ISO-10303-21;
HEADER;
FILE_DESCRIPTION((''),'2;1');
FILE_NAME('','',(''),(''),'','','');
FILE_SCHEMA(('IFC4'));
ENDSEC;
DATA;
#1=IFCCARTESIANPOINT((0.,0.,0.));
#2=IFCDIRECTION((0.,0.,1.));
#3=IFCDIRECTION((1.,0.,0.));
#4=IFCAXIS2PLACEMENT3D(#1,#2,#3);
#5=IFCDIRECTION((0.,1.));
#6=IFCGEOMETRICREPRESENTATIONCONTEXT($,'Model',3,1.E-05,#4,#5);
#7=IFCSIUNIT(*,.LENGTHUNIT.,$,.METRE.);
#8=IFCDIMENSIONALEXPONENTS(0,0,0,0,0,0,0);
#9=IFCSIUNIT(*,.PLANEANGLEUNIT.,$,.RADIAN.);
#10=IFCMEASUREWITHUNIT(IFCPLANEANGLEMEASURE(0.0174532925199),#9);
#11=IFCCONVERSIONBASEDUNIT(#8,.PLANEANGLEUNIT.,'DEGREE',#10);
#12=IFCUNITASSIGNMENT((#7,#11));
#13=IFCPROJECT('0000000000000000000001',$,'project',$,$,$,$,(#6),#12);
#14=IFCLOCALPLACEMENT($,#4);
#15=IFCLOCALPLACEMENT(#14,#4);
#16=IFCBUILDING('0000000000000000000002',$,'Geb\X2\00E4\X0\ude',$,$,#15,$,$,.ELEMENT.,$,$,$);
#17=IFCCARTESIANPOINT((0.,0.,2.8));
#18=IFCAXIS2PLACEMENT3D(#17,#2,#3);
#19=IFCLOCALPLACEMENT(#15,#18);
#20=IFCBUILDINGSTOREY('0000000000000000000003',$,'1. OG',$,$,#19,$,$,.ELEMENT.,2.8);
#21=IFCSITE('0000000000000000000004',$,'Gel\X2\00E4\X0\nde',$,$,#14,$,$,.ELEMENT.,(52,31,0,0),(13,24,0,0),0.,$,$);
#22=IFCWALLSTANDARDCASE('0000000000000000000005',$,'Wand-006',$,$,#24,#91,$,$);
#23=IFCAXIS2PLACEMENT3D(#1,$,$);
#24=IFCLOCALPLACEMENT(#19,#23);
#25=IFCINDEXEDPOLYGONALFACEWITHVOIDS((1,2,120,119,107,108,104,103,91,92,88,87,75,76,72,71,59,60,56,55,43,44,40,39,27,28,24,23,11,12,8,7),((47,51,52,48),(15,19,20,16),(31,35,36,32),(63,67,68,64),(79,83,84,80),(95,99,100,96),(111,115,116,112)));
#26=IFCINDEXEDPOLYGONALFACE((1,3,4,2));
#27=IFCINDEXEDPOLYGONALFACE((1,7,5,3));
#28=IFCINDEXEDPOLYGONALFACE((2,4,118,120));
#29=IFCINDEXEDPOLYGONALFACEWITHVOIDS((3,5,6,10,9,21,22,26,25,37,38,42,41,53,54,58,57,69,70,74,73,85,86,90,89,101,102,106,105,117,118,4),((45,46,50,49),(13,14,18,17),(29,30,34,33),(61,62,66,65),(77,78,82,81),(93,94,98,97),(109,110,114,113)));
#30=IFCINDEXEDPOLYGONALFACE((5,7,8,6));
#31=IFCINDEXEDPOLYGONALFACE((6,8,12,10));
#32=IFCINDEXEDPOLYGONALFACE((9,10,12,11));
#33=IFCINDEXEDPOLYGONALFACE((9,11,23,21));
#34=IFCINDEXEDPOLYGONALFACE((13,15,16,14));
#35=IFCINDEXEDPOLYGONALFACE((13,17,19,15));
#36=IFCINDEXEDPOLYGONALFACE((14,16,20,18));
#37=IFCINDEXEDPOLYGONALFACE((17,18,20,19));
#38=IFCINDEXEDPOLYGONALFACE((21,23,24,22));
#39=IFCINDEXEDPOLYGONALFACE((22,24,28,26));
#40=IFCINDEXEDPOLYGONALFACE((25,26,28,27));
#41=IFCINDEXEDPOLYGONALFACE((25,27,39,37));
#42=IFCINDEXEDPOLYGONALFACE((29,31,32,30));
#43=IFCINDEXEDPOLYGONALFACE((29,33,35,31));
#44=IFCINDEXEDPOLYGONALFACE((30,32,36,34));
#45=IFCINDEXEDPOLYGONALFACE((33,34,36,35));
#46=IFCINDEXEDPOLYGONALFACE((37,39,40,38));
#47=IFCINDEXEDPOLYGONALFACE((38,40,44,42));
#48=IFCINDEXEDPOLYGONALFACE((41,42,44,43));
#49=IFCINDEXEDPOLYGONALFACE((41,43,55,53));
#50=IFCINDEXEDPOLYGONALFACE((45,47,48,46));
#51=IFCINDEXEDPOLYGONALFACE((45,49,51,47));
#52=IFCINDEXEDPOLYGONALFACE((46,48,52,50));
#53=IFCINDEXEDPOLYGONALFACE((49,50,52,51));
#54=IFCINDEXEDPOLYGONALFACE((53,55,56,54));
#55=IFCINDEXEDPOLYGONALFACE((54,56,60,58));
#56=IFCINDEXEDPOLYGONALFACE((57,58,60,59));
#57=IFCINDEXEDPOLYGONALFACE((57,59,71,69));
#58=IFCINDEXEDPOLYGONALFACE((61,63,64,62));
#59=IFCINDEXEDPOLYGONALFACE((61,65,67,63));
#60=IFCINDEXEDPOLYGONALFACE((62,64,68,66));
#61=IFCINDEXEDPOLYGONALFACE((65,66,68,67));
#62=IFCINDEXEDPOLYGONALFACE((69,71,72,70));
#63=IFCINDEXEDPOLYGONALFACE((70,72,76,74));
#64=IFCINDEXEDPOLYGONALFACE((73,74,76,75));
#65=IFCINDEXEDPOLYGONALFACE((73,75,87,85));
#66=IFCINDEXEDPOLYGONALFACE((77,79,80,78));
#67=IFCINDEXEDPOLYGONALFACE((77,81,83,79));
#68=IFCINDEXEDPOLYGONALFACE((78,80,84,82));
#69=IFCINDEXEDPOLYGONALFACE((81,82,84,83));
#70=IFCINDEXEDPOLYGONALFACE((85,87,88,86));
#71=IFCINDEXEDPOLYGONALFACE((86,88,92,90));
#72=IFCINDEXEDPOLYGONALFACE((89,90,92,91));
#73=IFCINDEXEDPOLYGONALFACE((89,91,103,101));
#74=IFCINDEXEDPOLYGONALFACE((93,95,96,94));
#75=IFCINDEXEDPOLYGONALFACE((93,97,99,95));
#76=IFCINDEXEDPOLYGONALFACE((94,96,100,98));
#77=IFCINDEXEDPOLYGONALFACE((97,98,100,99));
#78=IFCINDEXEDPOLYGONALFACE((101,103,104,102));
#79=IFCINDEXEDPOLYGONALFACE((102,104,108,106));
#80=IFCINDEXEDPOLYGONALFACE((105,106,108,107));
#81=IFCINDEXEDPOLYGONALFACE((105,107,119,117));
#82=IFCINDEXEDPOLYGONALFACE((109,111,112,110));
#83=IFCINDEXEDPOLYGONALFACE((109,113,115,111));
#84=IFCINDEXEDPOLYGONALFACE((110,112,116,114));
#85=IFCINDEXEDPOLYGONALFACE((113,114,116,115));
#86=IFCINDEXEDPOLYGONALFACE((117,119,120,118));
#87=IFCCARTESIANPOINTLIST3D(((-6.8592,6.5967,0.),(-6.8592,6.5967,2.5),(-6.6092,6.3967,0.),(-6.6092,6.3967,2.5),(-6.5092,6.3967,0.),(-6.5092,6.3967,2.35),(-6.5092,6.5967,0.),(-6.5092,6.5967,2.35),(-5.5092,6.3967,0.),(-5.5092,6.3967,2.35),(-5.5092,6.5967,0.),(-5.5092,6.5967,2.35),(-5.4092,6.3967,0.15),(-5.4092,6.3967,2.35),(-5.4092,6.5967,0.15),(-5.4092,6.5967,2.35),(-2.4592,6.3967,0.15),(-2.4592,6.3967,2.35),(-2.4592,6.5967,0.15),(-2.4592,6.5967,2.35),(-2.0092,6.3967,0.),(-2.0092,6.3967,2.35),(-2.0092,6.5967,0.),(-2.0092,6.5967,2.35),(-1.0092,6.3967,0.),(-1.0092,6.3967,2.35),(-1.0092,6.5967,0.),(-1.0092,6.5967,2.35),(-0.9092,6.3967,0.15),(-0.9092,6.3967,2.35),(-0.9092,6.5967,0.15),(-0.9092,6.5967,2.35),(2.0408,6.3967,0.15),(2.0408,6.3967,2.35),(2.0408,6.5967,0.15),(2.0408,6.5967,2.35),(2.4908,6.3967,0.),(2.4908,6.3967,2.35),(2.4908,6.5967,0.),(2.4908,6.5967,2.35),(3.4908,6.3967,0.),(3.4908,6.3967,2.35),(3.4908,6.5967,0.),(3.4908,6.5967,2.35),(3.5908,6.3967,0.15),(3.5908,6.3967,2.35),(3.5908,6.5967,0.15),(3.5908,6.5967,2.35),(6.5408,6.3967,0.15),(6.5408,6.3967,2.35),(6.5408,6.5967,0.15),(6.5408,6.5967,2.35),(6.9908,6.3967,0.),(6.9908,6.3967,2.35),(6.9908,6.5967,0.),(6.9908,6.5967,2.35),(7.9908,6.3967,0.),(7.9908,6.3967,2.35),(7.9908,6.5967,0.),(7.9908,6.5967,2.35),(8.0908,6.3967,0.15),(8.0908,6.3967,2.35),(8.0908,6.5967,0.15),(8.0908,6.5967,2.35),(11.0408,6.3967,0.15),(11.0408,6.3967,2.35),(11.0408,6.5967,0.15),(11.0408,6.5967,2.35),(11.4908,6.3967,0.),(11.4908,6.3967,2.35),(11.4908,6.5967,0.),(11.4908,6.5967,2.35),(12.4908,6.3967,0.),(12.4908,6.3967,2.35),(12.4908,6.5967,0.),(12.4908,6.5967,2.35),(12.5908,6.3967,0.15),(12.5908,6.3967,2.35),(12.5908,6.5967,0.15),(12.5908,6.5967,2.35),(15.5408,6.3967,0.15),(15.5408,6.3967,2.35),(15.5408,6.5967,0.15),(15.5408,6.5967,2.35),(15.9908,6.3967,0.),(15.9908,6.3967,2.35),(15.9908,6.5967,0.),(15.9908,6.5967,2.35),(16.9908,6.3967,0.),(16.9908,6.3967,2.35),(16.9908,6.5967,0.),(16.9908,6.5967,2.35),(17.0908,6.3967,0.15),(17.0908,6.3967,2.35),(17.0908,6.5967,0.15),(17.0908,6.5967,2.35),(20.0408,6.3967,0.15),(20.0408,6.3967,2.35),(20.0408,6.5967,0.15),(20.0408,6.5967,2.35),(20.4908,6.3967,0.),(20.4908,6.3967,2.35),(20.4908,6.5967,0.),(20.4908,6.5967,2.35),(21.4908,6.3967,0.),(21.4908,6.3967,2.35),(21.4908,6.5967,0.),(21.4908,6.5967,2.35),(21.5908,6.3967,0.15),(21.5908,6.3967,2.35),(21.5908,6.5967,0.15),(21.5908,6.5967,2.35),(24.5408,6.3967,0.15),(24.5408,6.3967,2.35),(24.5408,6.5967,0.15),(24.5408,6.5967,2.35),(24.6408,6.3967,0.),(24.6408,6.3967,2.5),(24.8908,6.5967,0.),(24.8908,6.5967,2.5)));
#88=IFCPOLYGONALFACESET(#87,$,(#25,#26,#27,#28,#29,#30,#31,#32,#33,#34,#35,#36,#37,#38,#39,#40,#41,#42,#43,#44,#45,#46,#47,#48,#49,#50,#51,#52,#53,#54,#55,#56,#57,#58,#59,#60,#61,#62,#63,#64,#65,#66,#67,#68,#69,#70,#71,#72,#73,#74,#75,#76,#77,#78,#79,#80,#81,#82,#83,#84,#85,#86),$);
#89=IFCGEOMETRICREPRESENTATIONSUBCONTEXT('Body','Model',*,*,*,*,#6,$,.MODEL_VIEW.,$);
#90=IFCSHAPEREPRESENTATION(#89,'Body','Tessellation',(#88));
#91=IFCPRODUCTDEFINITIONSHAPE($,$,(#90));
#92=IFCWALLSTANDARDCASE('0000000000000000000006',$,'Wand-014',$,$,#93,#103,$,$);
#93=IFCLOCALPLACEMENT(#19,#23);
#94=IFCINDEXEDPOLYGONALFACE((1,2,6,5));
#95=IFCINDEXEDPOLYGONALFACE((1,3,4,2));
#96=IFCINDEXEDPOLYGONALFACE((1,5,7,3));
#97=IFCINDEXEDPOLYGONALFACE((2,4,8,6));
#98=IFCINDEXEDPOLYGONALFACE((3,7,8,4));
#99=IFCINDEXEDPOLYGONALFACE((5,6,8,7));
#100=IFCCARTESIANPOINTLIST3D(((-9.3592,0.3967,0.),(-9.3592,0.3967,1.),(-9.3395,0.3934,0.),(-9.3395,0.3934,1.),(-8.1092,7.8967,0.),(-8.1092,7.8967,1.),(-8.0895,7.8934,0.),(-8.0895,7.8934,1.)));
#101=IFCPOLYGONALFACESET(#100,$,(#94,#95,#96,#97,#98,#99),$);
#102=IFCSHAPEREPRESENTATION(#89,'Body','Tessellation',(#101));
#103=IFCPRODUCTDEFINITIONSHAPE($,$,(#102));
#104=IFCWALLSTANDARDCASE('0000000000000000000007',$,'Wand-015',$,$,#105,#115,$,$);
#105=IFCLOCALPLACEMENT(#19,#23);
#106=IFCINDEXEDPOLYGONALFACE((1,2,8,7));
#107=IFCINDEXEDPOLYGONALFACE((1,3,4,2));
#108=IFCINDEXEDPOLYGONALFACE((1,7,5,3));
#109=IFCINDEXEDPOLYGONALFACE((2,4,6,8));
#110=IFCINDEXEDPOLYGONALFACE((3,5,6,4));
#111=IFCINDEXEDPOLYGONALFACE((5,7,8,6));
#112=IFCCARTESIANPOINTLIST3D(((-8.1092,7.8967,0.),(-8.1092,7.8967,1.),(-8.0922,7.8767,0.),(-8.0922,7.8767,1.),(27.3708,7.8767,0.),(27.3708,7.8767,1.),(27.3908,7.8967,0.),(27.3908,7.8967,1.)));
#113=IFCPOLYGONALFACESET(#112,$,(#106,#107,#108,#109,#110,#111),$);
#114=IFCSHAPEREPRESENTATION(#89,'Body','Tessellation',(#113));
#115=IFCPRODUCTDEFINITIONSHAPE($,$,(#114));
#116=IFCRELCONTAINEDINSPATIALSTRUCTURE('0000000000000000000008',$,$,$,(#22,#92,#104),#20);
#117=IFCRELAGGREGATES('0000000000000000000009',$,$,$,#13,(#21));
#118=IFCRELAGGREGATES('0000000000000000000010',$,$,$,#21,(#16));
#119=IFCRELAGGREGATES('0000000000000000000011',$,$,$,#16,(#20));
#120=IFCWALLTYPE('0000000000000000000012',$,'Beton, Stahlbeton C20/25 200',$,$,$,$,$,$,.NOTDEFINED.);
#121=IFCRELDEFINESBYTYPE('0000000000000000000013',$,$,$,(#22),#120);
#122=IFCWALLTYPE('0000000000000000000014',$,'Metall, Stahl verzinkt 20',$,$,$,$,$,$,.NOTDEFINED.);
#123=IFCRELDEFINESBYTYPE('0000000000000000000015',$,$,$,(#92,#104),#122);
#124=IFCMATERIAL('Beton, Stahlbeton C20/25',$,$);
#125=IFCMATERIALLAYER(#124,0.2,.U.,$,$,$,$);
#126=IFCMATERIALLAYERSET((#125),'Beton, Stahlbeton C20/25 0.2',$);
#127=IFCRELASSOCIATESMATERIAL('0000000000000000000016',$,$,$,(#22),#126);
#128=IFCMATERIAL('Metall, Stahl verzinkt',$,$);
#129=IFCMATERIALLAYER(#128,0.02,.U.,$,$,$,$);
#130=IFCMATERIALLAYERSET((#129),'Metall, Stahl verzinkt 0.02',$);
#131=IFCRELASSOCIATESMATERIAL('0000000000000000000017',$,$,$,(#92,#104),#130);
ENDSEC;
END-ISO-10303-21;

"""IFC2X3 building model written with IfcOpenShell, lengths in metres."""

from ifc_helpers import new_model, entity, si_unit, converted_unit, direction, frame, origin_with_axes, origin_2d_with_axis, place, context, subcontext, project, spatial, polyline, rectangle, outline, extrude, material, layer, layer_set, layer_usage, type_object, element, save


model = new_model("IFC2X3")

# Units and contexts
model_context = context("Model", 3, precision=1e-05, world=origin_with_axes(), true_north=direction((0.0, 1.0)))
body_context = subcontext(model_context, "Body", "Model", "MODEL_VIEW")
ifc_project = project(units=[si_unit("LENGTHUNIT", "METRE"), converted_unit("PLANEANGLEUNIT", "DEGREE", entity("IfcPlaneAngleMeasure", 0.0174532925199), si_unit("PLANEANGLEUNIT", "RADIAN"), dimensions=[0, 0, 0, 0, 0, 0, 0])], contexts=[model_context])

# Site, building, storey
site_placement = place(None, origin_with_axes())
site = spatial("IfcSite", under=ifc_project, at=site_placement, Name="Gelände", CompositionType="ELEMENT", RefLatitude=(52, 31, 0, 0), RefLongitude=(13, 24, 0, 0), RefElevation=0.0)
building_placement = place(site_placement, origin_with_axes())
building = spatial("IfcBuilding", under=site, at=building_placement, Name="Gebäude", CompositionType="ELEMENT")
storey_placement = place(building_placement, frame((0.0, 0.0, 2.8), z_axis=(0.0, 0.0, 1.0), x_axis=(1.0, 0.0, 0.0)))
storey = spatial("IfcBuildingStorey", under=building, at=storey_placement, Name="1. OG", CompositionType="ELEMENT", Elevation=2.8)

# Shared definitions
ifc_material_1 = material(Name="Beton, Stahlbeton C20/25")

# Wall, openings
ifc_layer_1 = layer(ifc_material_1, 0.2, ventilated="UNKNOWN")
ifc_layer_set_1 = layer_set([ifc_layer_1], Name="Beton, Stahlbeton C20/25 0.2")
ifc_layer_usage_1 = layer_usage(ifc_layer_set_1, "AXIS2", "POSITIVE", 0.0)
wall_type_1 = type_object("IfcWallType", Name="Beton, Stahlbeton C20/25 200", PredefinedType="NOTDEFINED")
wall_1_placement = place(storey_placement, frame((-6.6092, 6.3967, 0.0), z_axis=(0.0, 0.0, 1.0), x_axis=(1.0, 0.0, 0.0)))
wall_1 = element("IfcWallStandardCase", 1, at=wall_1_placement, inside=storey, type_object=wall_type_1, material=ifc_layer_usage_1, Name="Wand-006", context=body_context, shape_type="SweptSolid", body=[
    extrude(outline(polyline([(0.0, 0.0), (31.25, 0.0), (31.5, 0.2), (-0.25, 0.2), (0.0, 0.0)])), origin_with_axes(), (0.0, 0.0, 1.0), 2.5),
])
opening_1_placement = place(wall_1_placement, frame((7.175, 0.0, 0.15), z_axis=(0.0, 0.0, 1.0), x_axis=(1.0, 0.0, 0.0)))
element("IfcOpeningElement", 2, at=opening_1_placement, cuts=wall_1, context=body_context, shape_type="SweptSolid", body=[
    extrude(rectangle(XDim=2.95, YDim=2.2, at=origin_2d_with_axis()), frame((0.0, -0.2, 1.1), z_axis=(0.0, -1.0, 0.0), x_axis=(1.0, 0.0, 0.0)), (0.0, 0.0, -1.0), 0.6),
])
opening_2_placement = place(wall_1_placement, frame((11.675, 0.0, 0.15), z_axis=(0.0, 0.0, 1.0), x_axis=(1.0, 0.0, 0.0)))
element("IfcOpeningElement", 3, at=opening_2_placement, cuts=wall_1, context=body_context, shape_type="SweptSolid", body=[
    extrude(rectangle(XDim=2.95, YDim=2.2, at=origin_2d_with_axis()), frame((0.0, -0.2, 1.1), z_axis=(0.0, -1.0, 0.0), x_axis=(1.0, 0.0, 0.0)), (0.0, 0.0, -1.0), 0.6),
])
opening_3_placement = place(wall_1_placement, frame((23.1, 0.0, 0.0), z_axis=(0.0, 0.0, 1.0), x_axis=(1.0, 0.0, 0.0)))
element("IfcOpeningElement", 4, at=opening_3_placement, cuts=wall_1, context=body_context, shape_type="SweptSolid", body=[
    extrude(rectangle(XDim=1.0, YDim=2.35, at=origin_2d_with_axis()), frame((0.0, 0.4, 1.175), z_axis=(0.0, 1.0, 0.0), x_axis=(-1.0, 0.0, 0.0)), (0.0, 0.0, -1.0), 0.6),
])
opening_4_placement = place(wall_1_placement, frame((18.6, 0.0, 0.0), z_axis=(0.0, 0.0, 1.0), x_axis=(1.0, 0.0, 0.0)))
element("IfcOpeningElement", 5, at=opening_4_placement, cuts=wall_1, context=body_context, shape_type="SweptSolid", body=[
    extrude(rectangle(XDim=1.0, YDim=2.35, at=origin_2d_with_axis()), frame((0.0, 0.4, 1.175), z_axis=(0.0, 1.0, 0.0), x_axis=(-1.0, 0.0, 0.0)), (0.0, 0.0, -1.0), 0.6),
])
opening_5_placement = place(wall_1_placement, frame((0.6, 0.0, 0.0), z_axis=(0.0, 0.0, 1.0), x_axis=(1.0, 0.0, 0.0)))
element("IfcOpeningElement", 6, at=opening_5_placement, cuts=wall_1, context=body_context, shape_type="SweptSolid", body=[
    extrude(rectangle(XDim=1.0, YDim=2.35, at=origin_2d_with_axis()), frame((0.0, 0.4, 1.175), z_axis=(0.0, 1.0, 0.0), x_axis=(-1.0, 0.0, 0.0)), (0.0, 0.0, -1.0), 0.6),
])
opening_6_placement = place(wall_1_placement, frame((25.175, 0.0, 0.15), z_axis=(0.0, 0.0, 1.0), x_axis=(1.0, 0.0, 0.0)))
element("IfcOpeningElement", 7, at=opening_6_placement, cuts=wall_1, context=body_context, shape_type="SweptSolid", body=[
    extrude(rectangle(XDim=2.95, YDim=2.2, at=origin_2d_with_axis()), frame((0.0, -0.2, 1.1), z_axis=(0.0, -1.0, 0.0), x_axis=(1.0, 0.0, 0.0)), (0.0, 0.0, -1.0), 0.6),
])
opening_7_placement = place(wall_1_placement, frame((9.6, 0.0, 0.0), z_axis=(0.0, 0.0, 1.0), x_axis=(1.0, 0.0, 0.0)))
element("IfcOpeningElement", 8, at=opening_7_placement, cuts=wall_1, context=body_context, shape_type="SweptSolid", body=[
    extrude(rectangle(XDim=1.0, YDim=2.35, at=origin_2d_with_axis()), frame((0.0, 0.4, 1.175), z_axis=(0.0, 1.0, 0.0), x_axis=(-1.0, 0.0, 0.0)), (0.0, 0.0, -1.0), 0.6),
])
opening_8_placement = place(wall_1_placement, frame((2.675, 0.0, 0.15), z_axis=(0.0, 0.0, 1.0), x_axis=(1.0, 0.0, 0.0)))
element("IfcOpeningElement", 9, at=opening_8_placement, cuts=wall_1, context=body_context, shape_type="SweptSolid", body=[
    extrude(rectangle(XDim=2.95, YDim=2.2, at=origin_2d_with_axis()), frame((0.0, -0.2, 1.1), z_axis=(0.0, -1.0, 0.0), x_axis=(1.0, 0.0, 0.0)), (0.0, 0.0, -1.0), 0.6),
])
opening_9_placement = place(wall_1_placement, frame((16.175, 0.0, 0.15), z_axis=(0.0, 0.0, 1.0), x_axis=(1.0, 0.0, 0.0)))
element("IfcOpeningElement", 10, at=opening_9_placement, cuts=wall_1, context=body_context, shape_type="SweptSolid", body=[
    extrude(rectangle(XDim=2.95, YDim=2.2, at=origin_2d_with_axis()), frame((0.0, -0.2, 1.1), z_axis=(0.0, -1.0, 0.0), x_axis=(1.0, 0.0, 0.0)), (0.0, 0.0, -1.0), 0.6),
])
opening_10_placement = place(wall_1_placement, frame((29.675, 0.0, 0.15), z_axis=(0.0, 0.0, 1.0), x_axis=(1.0, 0.0, 0.0)))
element("IfcOpeningElement", 11, at=opening_10_placement, cuts=wall_1, context=body_context, shape_type="SweptSolid", body=[
    extrude(rectangle(XDim=2.95, YDim=2.2, at=origin_2d_with_axis()), frame((0.0, -0.2, 1.1), z_axis=(0.0, -1.0, 0.0), x_axis=(1.0, 0.0, 0.0)), (0.0, 0.0, -1.0), 0.6),
])
opening_11_placement = place(wall_1_placement, frame((14.1, 0.0, 0.0), z_axis=(0.0, 0.0, 1.0), x_axis=(1.0, 0.0, 0.0)))
element("IfcOpeningElement", 12, at=opening_11_placement, cuts=wall_1, context=body_context, shape_type="SweptSolid", body=[
    extrude(rectangle(XDim=1.0, YDim=2.35, at=origin_2d_with_axis()), frame((0.0, 0.4, 1.175), z_axis=(0.0, 1.0, 0.0), x_axis=(-1.0, 0.0, 0.0)), (0.0, 0.0, -1.0), 0.6),
])
opening_12_placement = place(wall_1_placement, frame((20.675, 0.0, 0.15), z_axis=(0.0, 0.0, 1.0), x_axis=(1.0, 0.0, 0.0)))
element("IfcOpeningElement", 13, at=opening_12_placement, cuts=wall_1, context=body_context, shape_type="SweptSolid", body=[
    extrude(rectangle(XDim=2.95, YDim=2.2, at=origin_2d_with_axis()), frame((0.0, -0.2, 1.1), z_axis=(0.0, -1.0, 0.0), x_axis=(1.0, 0.0, 0.0)), (0.0, 0.0, -1.0), 0.6),
])
opening_13_placement = place(wall_1_placement, frame((27.6, 0.0, 0.0), z_axis=(0.0, 0.0, 1.0), x_axis=(1.0, 0.0, 0.0)))
element("IfcOpeningElement", 14, at=opening_13_placement, cuts=wall_1, context=body_context, shape_type="SweptSolid", body=[
    extrude(rectangle(XDim=1.0, YDim=2.35, at=origin_2d_with_axis()), frame((0.0, 0.4, 1.175), z_axis=(0.0, 1.0, 0.0), x_axis=(-1.0, 0.0, 0.0)), (0.0, 0.0, -1.0), 0.6),
])
opening_14_placement = place(wall_1_placement, frame((5.1, 0.0, 0.0), z_axis=(0.0, 0.0, 1.0), x_axis=(1.0, 0.0, 0.0)))
element("IfcOpeningElement", 15, at=opening_14_placement, cuts=wall_1, context=body_context, shape_type="SweptSolid", body=[
    extrude(rectangle(XDim=1.0, YDim=2.35, at=origin_2d_with_axis()), frame((0.0, 0.4, 1.175), z_axis=(0.0, 1.0, 0.0), x_axis=(-1.0, 0.0, 0.0)), (0.0, 0.0, -1.0), 0.6),
])

# Walls
ifc_material_2 = material(Name="Metall, Stahl verzinkt")
ifc_layer_2 = layer(ifc_material_2, 0.02, ventilated="UNKNOWN")
ifc_layer_set_2 = layer_set([ifc_layer_2], Name="Metall, Stahl verzinkt 0.02")
ifc_layer_usage_2 = layer_usage(ifc_layer_set_2, "AXIS2", "NEGATIVE", 0.0)
wall_type_2 = type_object("IfcWallType", Name="Metall, Stahl verzinkt 20", PredefinedType="NOTDEFINED")
wall_2_placement = place(storey_placement, frame((-9.3592, 0.3967, 0.0), z_axis=(0.0, 0.0, 1.0), x_axis=(0.164399, 0.986394, 0.0)))
element("IfcWallStandardCase", 16, at=wall_2_placement, inside=storey, type_object=wall_type_2, material=ifc_layer_usage_2, Name="Wand-014", context=body_context, shape_type="SweptSolid", body=[
    extrude(outline(polyline([(0.0, -0.02), (7.6035, -0.02), (7.6035, 0.0), (0.0, 0.0), (0.0, -0.02)])), origin_with_axes(), (0.0, 0.0, 1.0), 1.0),
])
ifc_layer_usage_3 = layer_usage(ifc_layer_set_2, "AXIS2", "NEGATIVE", 0.0)
wall_3_placement = place(storey_placement, frame((-8.1092, 7.8967, 0.0), z_axis=(0.0, 0.0, 1.0), x_axis=(1.0, 0.0, 0.0)))
element("IfcWallStandardCase", 17, at=wall_3_placement, inside=storey, type_object=wall_type_2, material=ifc_layer_usage_3, Name="Wand-015", context=body_context, shape_type="SweptSolid", body=[
    extrude(outline(polyline([(0.0169, -0.02), (35.48, -0.02), (35.5, 0.0), (0.0, 0.0), (0.0169, -0.02)])), origin_with_axes(), (0.0, 0.0, 1.0), 1.0),
])

save(model, "model.ifc")
